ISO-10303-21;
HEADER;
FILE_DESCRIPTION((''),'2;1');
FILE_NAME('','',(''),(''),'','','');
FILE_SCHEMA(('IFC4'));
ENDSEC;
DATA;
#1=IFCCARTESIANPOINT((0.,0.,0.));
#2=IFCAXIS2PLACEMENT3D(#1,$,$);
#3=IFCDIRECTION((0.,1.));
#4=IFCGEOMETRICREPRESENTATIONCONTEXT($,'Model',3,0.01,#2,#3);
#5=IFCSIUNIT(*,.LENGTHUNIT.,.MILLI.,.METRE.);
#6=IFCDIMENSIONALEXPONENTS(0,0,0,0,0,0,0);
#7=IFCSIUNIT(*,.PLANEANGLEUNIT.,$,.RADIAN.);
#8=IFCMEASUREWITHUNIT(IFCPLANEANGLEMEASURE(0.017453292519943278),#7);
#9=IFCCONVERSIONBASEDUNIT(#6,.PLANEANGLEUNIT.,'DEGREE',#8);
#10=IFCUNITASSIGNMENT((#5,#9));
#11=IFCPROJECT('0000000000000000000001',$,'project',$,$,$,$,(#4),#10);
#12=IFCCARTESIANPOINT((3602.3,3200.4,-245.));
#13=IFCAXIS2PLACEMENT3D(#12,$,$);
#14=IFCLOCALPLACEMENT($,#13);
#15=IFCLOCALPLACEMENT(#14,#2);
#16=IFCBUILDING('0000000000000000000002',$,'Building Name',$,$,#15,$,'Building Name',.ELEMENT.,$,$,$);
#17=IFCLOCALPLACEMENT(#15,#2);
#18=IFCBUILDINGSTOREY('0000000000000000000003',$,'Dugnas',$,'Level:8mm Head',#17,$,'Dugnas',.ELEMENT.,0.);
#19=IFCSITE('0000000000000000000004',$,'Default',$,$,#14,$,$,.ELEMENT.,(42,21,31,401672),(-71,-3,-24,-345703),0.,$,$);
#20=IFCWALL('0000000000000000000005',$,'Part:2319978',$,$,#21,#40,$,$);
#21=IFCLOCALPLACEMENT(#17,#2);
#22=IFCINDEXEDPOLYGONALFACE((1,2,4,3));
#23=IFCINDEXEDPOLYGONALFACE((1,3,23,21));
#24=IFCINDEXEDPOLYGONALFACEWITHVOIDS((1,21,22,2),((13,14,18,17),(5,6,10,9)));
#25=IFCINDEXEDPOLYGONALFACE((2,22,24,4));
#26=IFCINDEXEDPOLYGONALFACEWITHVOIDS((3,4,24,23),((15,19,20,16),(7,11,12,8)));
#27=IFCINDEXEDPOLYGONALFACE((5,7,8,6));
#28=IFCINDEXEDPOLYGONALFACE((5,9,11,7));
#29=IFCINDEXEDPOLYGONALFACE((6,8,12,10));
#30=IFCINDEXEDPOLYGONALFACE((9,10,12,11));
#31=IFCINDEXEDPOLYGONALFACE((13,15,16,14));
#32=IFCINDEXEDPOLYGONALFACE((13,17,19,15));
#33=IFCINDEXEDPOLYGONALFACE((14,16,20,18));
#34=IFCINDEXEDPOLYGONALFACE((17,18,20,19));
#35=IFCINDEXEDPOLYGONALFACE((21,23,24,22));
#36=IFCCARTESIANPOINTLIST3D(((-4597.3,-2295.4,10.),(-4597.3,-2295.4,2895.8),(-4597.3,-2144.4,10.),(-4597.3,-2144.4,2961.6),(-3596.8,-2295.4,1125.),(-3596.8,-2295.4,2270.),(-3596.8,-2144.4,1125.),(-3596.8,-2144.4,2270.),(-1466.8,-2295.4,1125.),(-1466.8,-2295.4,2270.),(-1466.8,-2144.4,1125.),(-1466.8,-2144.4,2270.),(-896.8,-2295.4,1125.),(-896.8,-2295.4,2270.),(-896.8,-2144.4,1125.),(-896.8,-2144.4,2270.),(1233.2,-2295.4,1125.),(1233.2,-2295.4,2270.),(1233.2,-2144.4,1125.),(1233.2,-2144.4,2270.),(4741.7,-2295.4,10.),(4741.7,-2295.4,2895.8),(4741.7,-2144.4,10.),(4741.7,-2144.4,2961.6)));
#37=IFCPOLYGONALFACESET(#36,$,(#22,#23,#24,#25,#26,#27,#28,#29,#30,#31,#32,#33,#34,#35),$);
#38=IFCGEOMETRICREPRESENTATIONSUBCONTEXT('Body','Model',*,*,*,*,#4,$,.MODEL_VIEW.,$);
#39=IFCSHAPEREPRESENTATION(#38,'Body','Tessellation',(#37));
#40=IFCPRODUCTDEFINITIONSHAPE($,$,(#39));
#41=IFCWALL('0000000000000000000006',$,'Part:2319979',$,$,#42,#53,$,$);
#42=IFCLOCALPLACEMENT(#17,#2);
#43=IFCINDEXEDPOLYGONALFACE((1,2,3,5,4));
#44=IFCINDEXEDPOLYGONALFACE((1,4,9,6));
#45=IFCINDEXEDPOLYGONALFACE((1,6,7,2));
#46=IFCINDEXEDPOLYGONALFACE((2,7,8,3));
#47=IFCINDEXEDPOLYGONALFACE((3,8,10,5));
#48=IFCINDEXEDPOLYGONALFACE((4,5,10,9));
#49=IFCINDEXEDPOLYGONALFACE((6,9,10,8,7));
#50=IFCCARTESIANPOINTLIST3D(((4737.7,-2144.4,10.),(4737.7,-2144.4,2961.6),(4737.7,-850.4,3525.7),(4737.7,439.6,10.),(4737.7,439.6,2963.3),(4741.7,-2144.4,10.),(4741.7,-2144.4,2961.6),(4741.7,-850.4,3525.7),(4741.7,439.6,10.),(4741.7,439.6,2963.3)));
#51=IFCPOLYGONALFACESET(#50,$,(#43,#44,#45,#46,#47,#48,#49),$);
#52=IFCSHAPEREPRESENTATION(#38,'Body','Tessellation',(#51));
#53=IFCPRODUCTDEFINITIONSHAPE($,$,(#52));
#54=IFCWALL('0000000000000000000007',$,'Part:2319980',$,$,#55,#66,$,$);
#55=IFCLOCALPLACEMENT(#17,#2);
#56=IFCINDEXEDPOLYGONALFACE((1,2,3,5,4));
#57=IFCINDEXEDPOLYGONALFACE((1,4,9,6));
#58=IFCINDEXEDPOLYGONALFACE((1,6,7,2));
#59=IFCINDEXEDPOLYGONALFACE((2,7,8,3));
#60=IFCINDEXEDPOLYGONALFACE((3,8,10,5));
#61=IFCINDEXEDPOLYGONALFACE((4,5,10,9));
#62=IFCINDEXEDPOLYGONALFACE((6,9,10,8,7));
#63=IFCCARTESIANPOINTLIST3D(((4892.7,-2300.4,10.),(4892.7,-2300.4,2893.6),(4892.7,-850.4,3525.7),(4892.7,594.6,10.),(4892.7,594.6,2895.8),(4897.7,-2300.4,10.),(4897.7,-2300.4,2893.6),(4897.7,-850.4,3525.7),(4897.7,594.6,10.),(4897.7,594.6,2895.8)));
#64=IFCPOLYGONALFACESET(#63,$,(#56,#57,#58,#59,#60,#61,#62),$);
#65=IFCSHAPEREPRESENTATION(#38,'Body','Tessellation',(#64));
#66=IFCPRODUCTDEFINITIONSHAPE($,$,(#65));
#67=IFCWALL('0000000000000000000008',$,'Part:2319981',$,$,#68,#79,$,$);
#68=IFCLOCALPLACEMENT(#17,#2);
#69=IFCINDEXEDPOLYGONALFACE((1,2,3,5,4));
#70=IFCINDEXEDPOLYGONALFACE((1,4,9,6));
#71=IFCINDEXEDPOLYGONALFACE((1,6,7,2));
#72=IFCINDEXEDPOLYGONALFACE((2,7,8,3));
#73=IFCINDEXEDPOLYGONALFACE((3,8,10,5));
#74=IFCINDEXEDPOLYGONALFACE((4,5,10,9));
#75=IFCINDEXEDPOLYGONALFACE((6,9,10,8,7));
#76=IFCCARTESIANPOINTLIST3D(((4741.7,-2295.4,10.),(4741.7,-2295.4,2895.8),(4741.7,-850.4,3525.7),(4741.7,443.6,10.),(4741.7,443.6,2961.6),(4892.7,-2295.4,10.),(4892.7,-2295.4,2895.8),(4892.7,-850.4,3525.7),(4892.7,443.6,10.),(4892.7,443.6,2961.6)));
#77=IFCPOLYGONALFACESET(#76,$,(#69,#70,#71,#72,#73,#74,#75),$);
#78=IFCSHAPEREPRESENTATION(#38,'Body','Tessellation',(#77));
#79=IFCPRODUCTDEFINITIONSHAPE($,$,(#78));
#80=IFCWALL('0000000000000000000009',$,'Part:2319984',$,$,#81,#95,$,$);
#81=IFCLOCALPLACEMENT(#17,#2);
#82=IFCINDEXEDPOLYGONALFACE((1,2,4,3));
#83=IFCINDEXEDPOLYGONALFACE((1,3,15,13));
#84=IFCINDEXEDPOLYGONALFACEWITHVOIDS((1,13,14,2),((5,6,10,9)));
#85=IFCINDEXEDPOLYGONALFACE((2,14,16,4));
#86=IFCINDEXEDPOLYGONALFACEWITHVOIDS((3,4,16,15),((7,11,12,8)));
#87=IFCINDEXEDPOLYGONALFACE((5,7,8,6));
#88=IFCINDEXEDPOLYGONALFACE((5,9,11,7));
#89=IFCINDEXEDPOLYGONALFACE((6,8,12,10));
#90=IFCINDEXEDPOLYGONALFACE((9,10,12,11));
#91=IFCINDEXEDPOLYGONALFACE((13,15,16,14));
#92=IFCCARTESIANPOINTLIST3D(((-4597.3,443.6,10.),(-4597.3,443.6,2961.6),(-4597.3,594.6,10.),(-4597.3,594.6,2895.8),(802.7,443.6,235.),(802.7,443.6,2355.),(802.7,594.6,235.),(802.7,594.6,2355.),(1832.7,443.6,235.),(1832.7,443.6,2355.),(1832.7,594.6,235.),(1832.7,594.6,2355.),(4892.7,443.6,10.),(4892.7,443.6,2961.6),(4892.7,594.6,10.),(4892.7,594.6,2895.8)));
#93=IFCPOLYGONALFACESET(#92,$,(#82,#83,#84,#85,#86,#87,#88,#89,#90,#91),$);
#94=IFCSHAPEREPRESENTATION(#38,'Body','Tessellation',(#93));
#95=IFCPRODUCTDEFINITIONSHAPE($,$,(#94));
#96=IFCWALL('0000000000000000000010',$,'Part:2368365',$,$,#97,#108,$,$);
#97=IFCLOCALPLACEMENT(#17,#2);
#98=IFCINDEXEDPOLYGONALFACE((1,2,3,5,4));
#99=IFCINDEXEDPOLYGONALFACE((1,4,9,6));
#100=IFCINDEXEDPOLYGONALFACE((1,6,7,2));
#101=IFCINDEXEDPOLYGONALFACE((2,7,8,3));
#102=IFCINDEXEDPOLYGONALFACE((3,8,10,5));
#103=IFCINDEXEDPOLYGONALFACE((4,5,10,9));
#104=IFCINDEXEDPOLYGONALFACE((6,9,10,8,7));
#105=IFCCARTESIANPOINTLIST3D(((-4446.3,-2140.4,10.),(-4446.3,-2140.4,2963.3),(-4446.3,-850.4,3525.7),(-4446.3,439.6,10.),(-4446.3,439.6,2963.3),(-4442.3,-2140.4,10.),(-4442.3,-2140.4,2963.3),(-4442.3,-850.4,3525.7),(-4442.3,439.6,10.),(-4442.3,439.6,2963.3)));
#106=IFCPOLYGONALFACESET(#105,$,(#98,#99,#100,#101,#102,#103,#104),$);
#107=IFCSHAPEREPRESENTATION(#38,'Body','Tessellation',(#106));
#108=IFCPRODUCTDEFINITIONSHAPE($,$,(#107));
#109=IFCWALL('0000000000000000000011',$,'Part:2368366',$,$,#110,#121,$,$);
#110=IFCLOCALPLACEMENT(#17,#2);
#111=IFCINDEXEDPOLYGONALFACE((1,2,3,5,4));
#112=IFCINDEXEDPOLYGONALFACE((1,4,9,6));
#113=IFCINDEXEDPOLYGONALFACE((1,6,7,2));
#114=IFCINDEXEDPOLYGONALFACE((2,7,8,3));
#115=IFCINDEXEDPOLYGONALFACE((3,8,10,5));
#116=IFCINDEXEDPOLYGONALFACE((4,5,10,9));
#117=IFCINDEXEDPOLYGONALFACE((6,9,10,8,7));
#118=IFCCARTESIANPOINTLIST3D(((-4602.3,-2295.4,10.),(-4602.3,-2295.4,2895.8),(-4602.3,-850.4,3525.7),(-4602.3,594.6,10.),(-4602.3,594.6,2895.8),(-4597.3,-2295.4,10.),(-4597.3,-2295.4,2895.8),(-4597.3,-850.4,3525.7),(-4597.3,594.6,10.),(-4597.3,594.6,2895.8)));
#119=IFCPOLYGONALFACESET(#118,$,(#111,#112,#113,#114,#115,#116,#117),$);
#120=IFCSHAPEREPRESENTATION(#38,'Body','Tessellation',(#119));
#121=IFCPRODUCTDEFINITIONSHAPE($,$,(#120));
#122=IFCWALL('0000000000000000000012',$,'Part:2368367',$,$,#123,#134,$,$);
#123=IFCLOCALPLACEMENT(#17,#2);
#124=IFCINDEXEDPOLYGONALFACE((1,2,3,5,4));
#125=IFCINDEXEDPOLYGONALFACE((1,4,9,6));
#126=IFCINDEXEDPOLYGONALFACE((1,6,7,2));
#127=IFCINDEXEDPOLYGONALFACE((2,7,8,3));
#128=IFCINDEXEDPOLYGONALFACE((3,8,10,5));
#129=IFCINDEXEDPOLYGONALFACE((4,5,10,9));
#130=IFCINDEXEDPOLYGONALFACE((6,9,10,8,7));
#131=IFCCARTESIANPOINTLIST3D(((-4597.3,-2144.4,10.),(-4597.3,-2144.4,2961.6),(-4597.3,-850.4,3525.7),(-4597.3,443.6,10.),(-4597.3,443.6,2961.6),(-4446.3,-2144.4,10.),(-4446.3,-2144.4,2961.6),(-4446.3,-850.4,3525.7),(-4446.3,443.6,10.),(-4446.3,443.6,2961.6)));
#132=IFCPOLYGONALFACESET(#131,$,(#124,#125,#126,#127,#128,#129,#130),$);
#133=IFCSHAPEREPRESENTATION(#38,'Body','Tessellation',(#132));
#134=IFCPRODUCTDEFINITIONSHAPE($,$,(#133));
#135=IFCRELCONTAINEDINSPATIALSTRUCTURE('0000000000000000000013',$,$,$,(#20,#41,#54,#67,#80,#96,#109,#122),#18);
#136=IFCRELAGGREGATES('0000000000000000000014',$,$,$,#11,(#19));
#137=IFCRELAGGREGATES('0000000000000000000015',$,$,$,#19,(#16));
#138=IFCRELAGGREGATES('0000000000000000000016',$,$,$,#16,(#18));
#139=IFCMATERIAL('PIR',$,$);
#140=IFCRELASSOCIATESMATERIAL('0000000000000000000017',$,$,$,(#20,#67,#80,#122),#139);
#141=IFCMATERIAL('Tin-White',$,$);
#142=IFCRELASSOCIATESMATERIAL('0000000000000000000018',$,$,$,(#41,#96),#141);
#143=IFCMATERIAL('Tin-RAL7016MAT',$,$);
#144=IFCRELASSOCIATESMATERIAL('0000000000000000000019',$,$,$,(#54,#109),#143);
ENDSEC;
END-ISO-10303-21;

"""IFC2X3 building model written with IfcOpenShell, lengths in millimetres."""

from ifc_helpers import new_model, entity, si_unit, converted_unit, direction, frame, frame_2d, origin, origin_2d_with_axis, place, context, subcontext, project, spatial, polyline, rectangle, extrude, boolean, clip, halfspace, bounded_halfspace, material, element, save


model = new_model("IFC2X3")

# Units and contexts
model_context = context("Model", 3, precision=0.01, world=origin(), true_north=direction((0.0, 1.0)))
body_context = subcontext(model_context, "Body", "Model", "MODEL_VIEW")
ifc_project = project(units=[si_unit("LENGTHUNIT", "METRE", prefix="MILLI"), converted_unit("PLANEANGLEUNIT", "DEGREE", entity("IfcPlaneAngleMeasure", 0.017453292519943278), si_unit("PLANEANGLEUNIT", "RADIAN"), dimensions=[0, 0, 0, 0, 0, 0, 0])], contexts=[model_context])

# Site, building, storey
site_placement = place(None, frame((3602.3, 3200.4, -245.0)))
site = spatial("IfcSite", under=ifc_project, at=site_placement, Name="Default", CompositionType="ELEMENT", RefLatitude=(42, 21, 31, 401672), RefLongitude=(-71, -3, -24, -345703), RefElevation=0.0)
building_placement = place(site_placement, origin())
building = spatial("IfcBuilding", under=site, at=building_placement, Name="Building Name", LongName="Building Name", CompositionType="ELEMENT")
storey_placement = place(building_placement, origin())
storey = spatial("IfcBuildingStorey", under=building, at=storey_placement, Name="Dugnas", ObjectType="Level:8mm Head", LongName="Dugnas", CompositionType="ELEMENT", Elevation=0.0)

# Walls
ifc_material_1 = material(Name="PIR")
wall_1_placement = place(storey_placement, frame((0.0, 0.0, 10.0)))
element("IfcWall", 1, at=wall_1_placement, inside=storey, material=ifc_material_1, Name="Part:2319978", context=body_context, shape_type="CSG", body=[
    boolean("DIFFERENCE", boolean("DIFFERENCE", clip(extrude(rectangle(XDim=151.0, YDim=9339.0, at=frame_2d((0.0, 0.0), x_axis=(1.0, 0.0))), frame((72.2, -2219.9, 0.0), z_axis=(0.0, 0.0, 1.0), x_axis=(0.0, -1.0, 0.0)), (0.0, 0.0, 1.0), 2951.6), halfspace(frame((-4702.3, -2400.4, 2840.0), z_axis=(0.0, -0.399598, 0.91669), x_axis=(1.0, 0.0, 0.0)), False)), extrude(rectangle(XDim=1145.0, YDim=2130.0, at=frame_2d((0.0, 0.0), x_axis=(0.0, 1.0))), frame((-2531.8, -2295.4, 1687.5), z_axis=(0.0, 1.0, 0.0), x_axis=(1.0, 0.0, 0.0)), (0.0, 0.0, 1.0), 151.0)), extrude(rectangle(XDim=1145.0, YDim=2130.0, at=frame_2d((0.0, 0.0), x_axis=(0.0, 1.0))), frame((168.2, -2295.4, 1687.5), z_axis=(0.0, 1.0, 0.0), x_axis=(1.0, 0.0, 0.0)), (0.0, 0.0, 1.0), 151.0)),
])
ifc_material_2 = material(Name="Tin-White")
wall_2_placement = place(storey_placement, frame((0.0, 0.0, 10.0)))
element("IfcWall", 2, at=wall_2_placement, inside=storey, material=ifc_material_2, Name="Part:2319979", context=body_context, shape_type="Clipping", body=[
    clip(clip(extrude(rectangle(XDim=4.0, YDim=2584.0, at=origin_2d_with_axis()), frame((4739.7, -852.4, 0.0)), (0.0, 0.0, 1.0), 3515.7), bounded_halfspace(frame((-4702.3, -2400.4, 2840.0), z_axis=(0.0, -0.399598, 0.91669), x_axis=(1.0, 0.0, 0.0)), False, frame((4739.7, -852.4, 0.0)), polyline([(-2.0, -1288.0), (-2.0, -1292.0), (2.0, -1292.0), (2.0, 2.0), (-2.0, 2.0), (-2.0, -1288.0)]))), bounded_halfspace(frame((4997.7, 699.6, 2840.0), z_axis=(0.0, 0.399598, 0.91669), x_axis=(-1.0, 0.0, 0.0)), False, frame((4739.7, -852.4, 0.0)), polyline([(-2.0, 1292.0), (-2.0, 2.0), (2.0, 2.0), (2.0, 1292.0), (-2.0, 1292.0)]))),
])
ifc_material_3 = material(Name="Tin-RAL7016MAT")
wall_3_placement = place(storey_placement, frame((0.0, 0.0, 10.0)))
element("IfcWall", 3, at=wall_3_placement, inside=storey, material=ifc_material_3, Name="Part:2319980", context=body_context, shape_type="Clipping", body=[
    clip(clip(extrude(rectangle(XDim=5.0, YDim=2895.0, at=frame_2d((0.0, 0.0), x_axis=(1.0, 0.0))), frame((4895.2, -852.9, 0.0)), (0.0, 0.0, 1.0), 3515.7), bounded_halfspace(frame((-4702.3, -2400.4, 2840.0), z_axis=(0.0, -0.399598, 0.91669), x_axis=(1.0, 0.0, 0.0)), False, frame((4895.2, -852.9, 0.0)), polyline([(2.5, -1447.5), (2.5, 2.5), (-2.5, 2.5), (-2.5, -1447.5), (2.5, -1447.5)]))), bounded_halfspace(frame((4997.7, 699.6, 2840.0), z_axis=(0.0, 0.399598, 0.91669), x_axis=(-1.0, 0.0, 0.0)), False, frame((4895.2, -852.9, 0.0)), polyline([(2.5, 2.5), (2.5, 1447.5), (-2.5, 1447.5), (-2.5, 2.5), (2.5, 2.5)]))),
])
wall_4_placement = place(storey_placement, frame((0.0, 0.0, 10.0)))
element("IfcWall", 4, at=wall_4_placement, inside=storey, material=ifc_material_1, Name="Part:2319981", context=body_context, shape_type="Clipping", body=[
    clip(clip(extrude(rectangle(XDim=151.0, YDim=2739.0, at=frame_2d((0.0, 0.0), x_axis=(1.0, 0.0))), frame((4817.2, -925.9, 0.0)), (0.0, 0.0, 1.0), 3515.7), bounded_halfspace(frame((-4702.3, -2400.4, 2840.0), z_axis=(0.0, -0.399598, 0.91669), x_axis=(1.0, 0.0, 0.0)), False, frame((4817.2, -925.9, 0.0)), polyline([(-75.5, -1369.5), (75.5, -1369.5), (75.5, 75.5), (-75.5, 75.5), (-75.5, -1369.5)]))), bounded_halfspace(frame((4997.7, 699.6, 2840.0), z_axis=(0.0, 0.399598, 0.91669), x_axis=(-1.0, 0.0, 0.0)), False, frame((4817.2, -925.9, 0.0)), polyline([(75.5, 1369.5), (-75.5, 1369.5), (-75.5, 75.5), (75.5, 75.5), (75.5, 1369.5)]))),
])
wall_5_placement = place(storey_placement, frame((0.0, 0.0, 10.0)))
element("IfcWall", 5, at=wall_5_placement, inside=storey, material=ifc_material_1, Name="Part:2319984", context=body_context, shape_type="CSG", body=[
    boolean("DIFFERENCE", clip(extrude(rectangle(XDim=151.0, YDim=9490.0, at=frame_2d((0.0, 0.0), x_axis=(1.0, 0.0))), frame((147.7, 519.1, 0.0), z_axis=(0.0, 0.0, 1.0), x_axis=(0.0, -1.0, 0.0)), (0.0, 0.0, 1.0), 2951.6), halfspace(frame((4997.7, 699.6, 2840.0), z_axis=(0.0, 0.399598, 0.91669), x_axis=(-1.0, 0.0, 0.0)), False)), extrude(rectangle(XDim=2120.0, YDim=1030.0, at=frame_2d((0.0, 0.0), x_axis=(0.0, 1.0))), frame((1317.7, 443.6, 1285.0), z_axis=(0.0, 1.0, 0.0), x_axis=(1.0, 0.0, 0.0)), (0.0, 0.0, 1.0), 151.0)),
])
wall_6_placement = place(storey_placement, frame((0.0, 0.0, 10.0)))
element("IfcWall", 6, at=wall_6_placement, inside=storey, material=ifc_material_2, Name="Part:2368365", context=body_context, shape_type="Clipping", body=[
    clip(clip(extrude(rectangle(XDim=4.0, YDim=2580.0, at=frame_2d((0.0, 0.0), x_axis=(1.0, 0.0))), frame((-4444.3, -850.4, 0.0)), (0.0, 0.0, 1.0), 3515.7), bounded_halfspace(frame((-4702.3, -2400.4, 2840.0), z_axis=(0.0, -0.399598, 0.91669), x_axis=(1.0, 0.0, 0.0)), False, frame((-4444.3, -850.4, 0.0)), polyline([(2.0, -1290.0), (2.0, 0.0), (-2.0, 0.0), (-2.0, -1290.0), (2.0, -1290.0)]))), bounded_halfspace(frame((4997.7, 699.6, 2840.0), z_axis=(0.0, 0.399598, 0.91669), x_axis=(-1.0, 0.0, 0.0)), False, frame((-4444.3, -850.4, 0.0)), polyline([(2.0, 0.0), (2.0, 1290.0), (-2.0, 1290.0), (-2.0, 0.0), (2.0, 0.0)]))),
])
wall_7_placement = place(storey_placement, frame((0.0, 0.0, 10.0)))
element("IfcWall", 7, at=wall_7_placement, inside=storey, material=ifc_material_3, Name="Part:2368366", context=body_context, shape_type="Clipping", body=[
    clip(clip(extrude(rectangle(XDim=5.0, YDim=2890.0, at=frame_2d((0.0, 0.0), x_axis=(1.0, 0.0))), frame((-4599.8, -850.4, 0.0)), (0.0, 0.0, 1.0), 3515.7), bounded_halfspace(frame((-4702.3, -2400.4, 2840.0), z_axis=(0.0, -0.399598, 0.91669), x_axis=(1.0, 0.0, 0.0)), False, frame((-4599.8, -850.4, 0.0)), polyline([(-2.5, 0.0), (-2.5, -1445.0), (2.5, -1445.0), (2.5, 0.0), (-2.5, 0.0)]))), bounded_halfspace(frame((4997.7, 699.6, 2840.0), z_axis=(0.0, 0.399598, 0.91669), x_axis=(-1.0, 0.0, 0.0)), False, frame((-4599.8, -850.4, 0.0)), polyline([(-2.5, 1445.0), (-2.5, 0.0), (2.5, 0.0), (2.5, 1445.0), (-2.5, 1445.0)]))),
])
wall_8_placement = place(storey_placement, frame((0.0, 0.0, 10.0)))
element("IfcWall", 8, at=wall_8_placement, inside=storey, material=ifc_material_1, Name="Part:2368367", context=body_context, shape_type="Clipping", body=[
    clip(clip(extrude(rectangle(XDim=151.0, YDim=2588.0, at=origin_2d_with_axis()), frame((-4521.8, -850.4, 0.0)), (0.0, 0.0, 1.0), 3515.7), bounded_halfspace(frame((-4702.3, -2400.4, 2840.0), z_axis=(0.0, -0.399598, 0.91669), x_axis=(1.0, 0.0, 0.0)), False, frame((-4521.8, -850.4, 0.0)), polyline([(-75.5, -1294.0), (75.5, -1294.0), (75.5, 0.0), (-75.5, 0.0), (-75.5, -1294.0)]))), bounded_halfspace(frame((4997.7, 699.6, 2840.0), z_axis=(0.0, 0.399598, 0.91669), x_axis=(-1.0, 0.0, 0.0)), False, frame((-4521.8, -850.4, 0.0)), polyline([(75.5, 1294.0), (-75.5, 1294.0), (-75.5, 0.0), (75.5, 0.0), (75.5, 1294.0)]))),
])

save(model, "model.ifc")
